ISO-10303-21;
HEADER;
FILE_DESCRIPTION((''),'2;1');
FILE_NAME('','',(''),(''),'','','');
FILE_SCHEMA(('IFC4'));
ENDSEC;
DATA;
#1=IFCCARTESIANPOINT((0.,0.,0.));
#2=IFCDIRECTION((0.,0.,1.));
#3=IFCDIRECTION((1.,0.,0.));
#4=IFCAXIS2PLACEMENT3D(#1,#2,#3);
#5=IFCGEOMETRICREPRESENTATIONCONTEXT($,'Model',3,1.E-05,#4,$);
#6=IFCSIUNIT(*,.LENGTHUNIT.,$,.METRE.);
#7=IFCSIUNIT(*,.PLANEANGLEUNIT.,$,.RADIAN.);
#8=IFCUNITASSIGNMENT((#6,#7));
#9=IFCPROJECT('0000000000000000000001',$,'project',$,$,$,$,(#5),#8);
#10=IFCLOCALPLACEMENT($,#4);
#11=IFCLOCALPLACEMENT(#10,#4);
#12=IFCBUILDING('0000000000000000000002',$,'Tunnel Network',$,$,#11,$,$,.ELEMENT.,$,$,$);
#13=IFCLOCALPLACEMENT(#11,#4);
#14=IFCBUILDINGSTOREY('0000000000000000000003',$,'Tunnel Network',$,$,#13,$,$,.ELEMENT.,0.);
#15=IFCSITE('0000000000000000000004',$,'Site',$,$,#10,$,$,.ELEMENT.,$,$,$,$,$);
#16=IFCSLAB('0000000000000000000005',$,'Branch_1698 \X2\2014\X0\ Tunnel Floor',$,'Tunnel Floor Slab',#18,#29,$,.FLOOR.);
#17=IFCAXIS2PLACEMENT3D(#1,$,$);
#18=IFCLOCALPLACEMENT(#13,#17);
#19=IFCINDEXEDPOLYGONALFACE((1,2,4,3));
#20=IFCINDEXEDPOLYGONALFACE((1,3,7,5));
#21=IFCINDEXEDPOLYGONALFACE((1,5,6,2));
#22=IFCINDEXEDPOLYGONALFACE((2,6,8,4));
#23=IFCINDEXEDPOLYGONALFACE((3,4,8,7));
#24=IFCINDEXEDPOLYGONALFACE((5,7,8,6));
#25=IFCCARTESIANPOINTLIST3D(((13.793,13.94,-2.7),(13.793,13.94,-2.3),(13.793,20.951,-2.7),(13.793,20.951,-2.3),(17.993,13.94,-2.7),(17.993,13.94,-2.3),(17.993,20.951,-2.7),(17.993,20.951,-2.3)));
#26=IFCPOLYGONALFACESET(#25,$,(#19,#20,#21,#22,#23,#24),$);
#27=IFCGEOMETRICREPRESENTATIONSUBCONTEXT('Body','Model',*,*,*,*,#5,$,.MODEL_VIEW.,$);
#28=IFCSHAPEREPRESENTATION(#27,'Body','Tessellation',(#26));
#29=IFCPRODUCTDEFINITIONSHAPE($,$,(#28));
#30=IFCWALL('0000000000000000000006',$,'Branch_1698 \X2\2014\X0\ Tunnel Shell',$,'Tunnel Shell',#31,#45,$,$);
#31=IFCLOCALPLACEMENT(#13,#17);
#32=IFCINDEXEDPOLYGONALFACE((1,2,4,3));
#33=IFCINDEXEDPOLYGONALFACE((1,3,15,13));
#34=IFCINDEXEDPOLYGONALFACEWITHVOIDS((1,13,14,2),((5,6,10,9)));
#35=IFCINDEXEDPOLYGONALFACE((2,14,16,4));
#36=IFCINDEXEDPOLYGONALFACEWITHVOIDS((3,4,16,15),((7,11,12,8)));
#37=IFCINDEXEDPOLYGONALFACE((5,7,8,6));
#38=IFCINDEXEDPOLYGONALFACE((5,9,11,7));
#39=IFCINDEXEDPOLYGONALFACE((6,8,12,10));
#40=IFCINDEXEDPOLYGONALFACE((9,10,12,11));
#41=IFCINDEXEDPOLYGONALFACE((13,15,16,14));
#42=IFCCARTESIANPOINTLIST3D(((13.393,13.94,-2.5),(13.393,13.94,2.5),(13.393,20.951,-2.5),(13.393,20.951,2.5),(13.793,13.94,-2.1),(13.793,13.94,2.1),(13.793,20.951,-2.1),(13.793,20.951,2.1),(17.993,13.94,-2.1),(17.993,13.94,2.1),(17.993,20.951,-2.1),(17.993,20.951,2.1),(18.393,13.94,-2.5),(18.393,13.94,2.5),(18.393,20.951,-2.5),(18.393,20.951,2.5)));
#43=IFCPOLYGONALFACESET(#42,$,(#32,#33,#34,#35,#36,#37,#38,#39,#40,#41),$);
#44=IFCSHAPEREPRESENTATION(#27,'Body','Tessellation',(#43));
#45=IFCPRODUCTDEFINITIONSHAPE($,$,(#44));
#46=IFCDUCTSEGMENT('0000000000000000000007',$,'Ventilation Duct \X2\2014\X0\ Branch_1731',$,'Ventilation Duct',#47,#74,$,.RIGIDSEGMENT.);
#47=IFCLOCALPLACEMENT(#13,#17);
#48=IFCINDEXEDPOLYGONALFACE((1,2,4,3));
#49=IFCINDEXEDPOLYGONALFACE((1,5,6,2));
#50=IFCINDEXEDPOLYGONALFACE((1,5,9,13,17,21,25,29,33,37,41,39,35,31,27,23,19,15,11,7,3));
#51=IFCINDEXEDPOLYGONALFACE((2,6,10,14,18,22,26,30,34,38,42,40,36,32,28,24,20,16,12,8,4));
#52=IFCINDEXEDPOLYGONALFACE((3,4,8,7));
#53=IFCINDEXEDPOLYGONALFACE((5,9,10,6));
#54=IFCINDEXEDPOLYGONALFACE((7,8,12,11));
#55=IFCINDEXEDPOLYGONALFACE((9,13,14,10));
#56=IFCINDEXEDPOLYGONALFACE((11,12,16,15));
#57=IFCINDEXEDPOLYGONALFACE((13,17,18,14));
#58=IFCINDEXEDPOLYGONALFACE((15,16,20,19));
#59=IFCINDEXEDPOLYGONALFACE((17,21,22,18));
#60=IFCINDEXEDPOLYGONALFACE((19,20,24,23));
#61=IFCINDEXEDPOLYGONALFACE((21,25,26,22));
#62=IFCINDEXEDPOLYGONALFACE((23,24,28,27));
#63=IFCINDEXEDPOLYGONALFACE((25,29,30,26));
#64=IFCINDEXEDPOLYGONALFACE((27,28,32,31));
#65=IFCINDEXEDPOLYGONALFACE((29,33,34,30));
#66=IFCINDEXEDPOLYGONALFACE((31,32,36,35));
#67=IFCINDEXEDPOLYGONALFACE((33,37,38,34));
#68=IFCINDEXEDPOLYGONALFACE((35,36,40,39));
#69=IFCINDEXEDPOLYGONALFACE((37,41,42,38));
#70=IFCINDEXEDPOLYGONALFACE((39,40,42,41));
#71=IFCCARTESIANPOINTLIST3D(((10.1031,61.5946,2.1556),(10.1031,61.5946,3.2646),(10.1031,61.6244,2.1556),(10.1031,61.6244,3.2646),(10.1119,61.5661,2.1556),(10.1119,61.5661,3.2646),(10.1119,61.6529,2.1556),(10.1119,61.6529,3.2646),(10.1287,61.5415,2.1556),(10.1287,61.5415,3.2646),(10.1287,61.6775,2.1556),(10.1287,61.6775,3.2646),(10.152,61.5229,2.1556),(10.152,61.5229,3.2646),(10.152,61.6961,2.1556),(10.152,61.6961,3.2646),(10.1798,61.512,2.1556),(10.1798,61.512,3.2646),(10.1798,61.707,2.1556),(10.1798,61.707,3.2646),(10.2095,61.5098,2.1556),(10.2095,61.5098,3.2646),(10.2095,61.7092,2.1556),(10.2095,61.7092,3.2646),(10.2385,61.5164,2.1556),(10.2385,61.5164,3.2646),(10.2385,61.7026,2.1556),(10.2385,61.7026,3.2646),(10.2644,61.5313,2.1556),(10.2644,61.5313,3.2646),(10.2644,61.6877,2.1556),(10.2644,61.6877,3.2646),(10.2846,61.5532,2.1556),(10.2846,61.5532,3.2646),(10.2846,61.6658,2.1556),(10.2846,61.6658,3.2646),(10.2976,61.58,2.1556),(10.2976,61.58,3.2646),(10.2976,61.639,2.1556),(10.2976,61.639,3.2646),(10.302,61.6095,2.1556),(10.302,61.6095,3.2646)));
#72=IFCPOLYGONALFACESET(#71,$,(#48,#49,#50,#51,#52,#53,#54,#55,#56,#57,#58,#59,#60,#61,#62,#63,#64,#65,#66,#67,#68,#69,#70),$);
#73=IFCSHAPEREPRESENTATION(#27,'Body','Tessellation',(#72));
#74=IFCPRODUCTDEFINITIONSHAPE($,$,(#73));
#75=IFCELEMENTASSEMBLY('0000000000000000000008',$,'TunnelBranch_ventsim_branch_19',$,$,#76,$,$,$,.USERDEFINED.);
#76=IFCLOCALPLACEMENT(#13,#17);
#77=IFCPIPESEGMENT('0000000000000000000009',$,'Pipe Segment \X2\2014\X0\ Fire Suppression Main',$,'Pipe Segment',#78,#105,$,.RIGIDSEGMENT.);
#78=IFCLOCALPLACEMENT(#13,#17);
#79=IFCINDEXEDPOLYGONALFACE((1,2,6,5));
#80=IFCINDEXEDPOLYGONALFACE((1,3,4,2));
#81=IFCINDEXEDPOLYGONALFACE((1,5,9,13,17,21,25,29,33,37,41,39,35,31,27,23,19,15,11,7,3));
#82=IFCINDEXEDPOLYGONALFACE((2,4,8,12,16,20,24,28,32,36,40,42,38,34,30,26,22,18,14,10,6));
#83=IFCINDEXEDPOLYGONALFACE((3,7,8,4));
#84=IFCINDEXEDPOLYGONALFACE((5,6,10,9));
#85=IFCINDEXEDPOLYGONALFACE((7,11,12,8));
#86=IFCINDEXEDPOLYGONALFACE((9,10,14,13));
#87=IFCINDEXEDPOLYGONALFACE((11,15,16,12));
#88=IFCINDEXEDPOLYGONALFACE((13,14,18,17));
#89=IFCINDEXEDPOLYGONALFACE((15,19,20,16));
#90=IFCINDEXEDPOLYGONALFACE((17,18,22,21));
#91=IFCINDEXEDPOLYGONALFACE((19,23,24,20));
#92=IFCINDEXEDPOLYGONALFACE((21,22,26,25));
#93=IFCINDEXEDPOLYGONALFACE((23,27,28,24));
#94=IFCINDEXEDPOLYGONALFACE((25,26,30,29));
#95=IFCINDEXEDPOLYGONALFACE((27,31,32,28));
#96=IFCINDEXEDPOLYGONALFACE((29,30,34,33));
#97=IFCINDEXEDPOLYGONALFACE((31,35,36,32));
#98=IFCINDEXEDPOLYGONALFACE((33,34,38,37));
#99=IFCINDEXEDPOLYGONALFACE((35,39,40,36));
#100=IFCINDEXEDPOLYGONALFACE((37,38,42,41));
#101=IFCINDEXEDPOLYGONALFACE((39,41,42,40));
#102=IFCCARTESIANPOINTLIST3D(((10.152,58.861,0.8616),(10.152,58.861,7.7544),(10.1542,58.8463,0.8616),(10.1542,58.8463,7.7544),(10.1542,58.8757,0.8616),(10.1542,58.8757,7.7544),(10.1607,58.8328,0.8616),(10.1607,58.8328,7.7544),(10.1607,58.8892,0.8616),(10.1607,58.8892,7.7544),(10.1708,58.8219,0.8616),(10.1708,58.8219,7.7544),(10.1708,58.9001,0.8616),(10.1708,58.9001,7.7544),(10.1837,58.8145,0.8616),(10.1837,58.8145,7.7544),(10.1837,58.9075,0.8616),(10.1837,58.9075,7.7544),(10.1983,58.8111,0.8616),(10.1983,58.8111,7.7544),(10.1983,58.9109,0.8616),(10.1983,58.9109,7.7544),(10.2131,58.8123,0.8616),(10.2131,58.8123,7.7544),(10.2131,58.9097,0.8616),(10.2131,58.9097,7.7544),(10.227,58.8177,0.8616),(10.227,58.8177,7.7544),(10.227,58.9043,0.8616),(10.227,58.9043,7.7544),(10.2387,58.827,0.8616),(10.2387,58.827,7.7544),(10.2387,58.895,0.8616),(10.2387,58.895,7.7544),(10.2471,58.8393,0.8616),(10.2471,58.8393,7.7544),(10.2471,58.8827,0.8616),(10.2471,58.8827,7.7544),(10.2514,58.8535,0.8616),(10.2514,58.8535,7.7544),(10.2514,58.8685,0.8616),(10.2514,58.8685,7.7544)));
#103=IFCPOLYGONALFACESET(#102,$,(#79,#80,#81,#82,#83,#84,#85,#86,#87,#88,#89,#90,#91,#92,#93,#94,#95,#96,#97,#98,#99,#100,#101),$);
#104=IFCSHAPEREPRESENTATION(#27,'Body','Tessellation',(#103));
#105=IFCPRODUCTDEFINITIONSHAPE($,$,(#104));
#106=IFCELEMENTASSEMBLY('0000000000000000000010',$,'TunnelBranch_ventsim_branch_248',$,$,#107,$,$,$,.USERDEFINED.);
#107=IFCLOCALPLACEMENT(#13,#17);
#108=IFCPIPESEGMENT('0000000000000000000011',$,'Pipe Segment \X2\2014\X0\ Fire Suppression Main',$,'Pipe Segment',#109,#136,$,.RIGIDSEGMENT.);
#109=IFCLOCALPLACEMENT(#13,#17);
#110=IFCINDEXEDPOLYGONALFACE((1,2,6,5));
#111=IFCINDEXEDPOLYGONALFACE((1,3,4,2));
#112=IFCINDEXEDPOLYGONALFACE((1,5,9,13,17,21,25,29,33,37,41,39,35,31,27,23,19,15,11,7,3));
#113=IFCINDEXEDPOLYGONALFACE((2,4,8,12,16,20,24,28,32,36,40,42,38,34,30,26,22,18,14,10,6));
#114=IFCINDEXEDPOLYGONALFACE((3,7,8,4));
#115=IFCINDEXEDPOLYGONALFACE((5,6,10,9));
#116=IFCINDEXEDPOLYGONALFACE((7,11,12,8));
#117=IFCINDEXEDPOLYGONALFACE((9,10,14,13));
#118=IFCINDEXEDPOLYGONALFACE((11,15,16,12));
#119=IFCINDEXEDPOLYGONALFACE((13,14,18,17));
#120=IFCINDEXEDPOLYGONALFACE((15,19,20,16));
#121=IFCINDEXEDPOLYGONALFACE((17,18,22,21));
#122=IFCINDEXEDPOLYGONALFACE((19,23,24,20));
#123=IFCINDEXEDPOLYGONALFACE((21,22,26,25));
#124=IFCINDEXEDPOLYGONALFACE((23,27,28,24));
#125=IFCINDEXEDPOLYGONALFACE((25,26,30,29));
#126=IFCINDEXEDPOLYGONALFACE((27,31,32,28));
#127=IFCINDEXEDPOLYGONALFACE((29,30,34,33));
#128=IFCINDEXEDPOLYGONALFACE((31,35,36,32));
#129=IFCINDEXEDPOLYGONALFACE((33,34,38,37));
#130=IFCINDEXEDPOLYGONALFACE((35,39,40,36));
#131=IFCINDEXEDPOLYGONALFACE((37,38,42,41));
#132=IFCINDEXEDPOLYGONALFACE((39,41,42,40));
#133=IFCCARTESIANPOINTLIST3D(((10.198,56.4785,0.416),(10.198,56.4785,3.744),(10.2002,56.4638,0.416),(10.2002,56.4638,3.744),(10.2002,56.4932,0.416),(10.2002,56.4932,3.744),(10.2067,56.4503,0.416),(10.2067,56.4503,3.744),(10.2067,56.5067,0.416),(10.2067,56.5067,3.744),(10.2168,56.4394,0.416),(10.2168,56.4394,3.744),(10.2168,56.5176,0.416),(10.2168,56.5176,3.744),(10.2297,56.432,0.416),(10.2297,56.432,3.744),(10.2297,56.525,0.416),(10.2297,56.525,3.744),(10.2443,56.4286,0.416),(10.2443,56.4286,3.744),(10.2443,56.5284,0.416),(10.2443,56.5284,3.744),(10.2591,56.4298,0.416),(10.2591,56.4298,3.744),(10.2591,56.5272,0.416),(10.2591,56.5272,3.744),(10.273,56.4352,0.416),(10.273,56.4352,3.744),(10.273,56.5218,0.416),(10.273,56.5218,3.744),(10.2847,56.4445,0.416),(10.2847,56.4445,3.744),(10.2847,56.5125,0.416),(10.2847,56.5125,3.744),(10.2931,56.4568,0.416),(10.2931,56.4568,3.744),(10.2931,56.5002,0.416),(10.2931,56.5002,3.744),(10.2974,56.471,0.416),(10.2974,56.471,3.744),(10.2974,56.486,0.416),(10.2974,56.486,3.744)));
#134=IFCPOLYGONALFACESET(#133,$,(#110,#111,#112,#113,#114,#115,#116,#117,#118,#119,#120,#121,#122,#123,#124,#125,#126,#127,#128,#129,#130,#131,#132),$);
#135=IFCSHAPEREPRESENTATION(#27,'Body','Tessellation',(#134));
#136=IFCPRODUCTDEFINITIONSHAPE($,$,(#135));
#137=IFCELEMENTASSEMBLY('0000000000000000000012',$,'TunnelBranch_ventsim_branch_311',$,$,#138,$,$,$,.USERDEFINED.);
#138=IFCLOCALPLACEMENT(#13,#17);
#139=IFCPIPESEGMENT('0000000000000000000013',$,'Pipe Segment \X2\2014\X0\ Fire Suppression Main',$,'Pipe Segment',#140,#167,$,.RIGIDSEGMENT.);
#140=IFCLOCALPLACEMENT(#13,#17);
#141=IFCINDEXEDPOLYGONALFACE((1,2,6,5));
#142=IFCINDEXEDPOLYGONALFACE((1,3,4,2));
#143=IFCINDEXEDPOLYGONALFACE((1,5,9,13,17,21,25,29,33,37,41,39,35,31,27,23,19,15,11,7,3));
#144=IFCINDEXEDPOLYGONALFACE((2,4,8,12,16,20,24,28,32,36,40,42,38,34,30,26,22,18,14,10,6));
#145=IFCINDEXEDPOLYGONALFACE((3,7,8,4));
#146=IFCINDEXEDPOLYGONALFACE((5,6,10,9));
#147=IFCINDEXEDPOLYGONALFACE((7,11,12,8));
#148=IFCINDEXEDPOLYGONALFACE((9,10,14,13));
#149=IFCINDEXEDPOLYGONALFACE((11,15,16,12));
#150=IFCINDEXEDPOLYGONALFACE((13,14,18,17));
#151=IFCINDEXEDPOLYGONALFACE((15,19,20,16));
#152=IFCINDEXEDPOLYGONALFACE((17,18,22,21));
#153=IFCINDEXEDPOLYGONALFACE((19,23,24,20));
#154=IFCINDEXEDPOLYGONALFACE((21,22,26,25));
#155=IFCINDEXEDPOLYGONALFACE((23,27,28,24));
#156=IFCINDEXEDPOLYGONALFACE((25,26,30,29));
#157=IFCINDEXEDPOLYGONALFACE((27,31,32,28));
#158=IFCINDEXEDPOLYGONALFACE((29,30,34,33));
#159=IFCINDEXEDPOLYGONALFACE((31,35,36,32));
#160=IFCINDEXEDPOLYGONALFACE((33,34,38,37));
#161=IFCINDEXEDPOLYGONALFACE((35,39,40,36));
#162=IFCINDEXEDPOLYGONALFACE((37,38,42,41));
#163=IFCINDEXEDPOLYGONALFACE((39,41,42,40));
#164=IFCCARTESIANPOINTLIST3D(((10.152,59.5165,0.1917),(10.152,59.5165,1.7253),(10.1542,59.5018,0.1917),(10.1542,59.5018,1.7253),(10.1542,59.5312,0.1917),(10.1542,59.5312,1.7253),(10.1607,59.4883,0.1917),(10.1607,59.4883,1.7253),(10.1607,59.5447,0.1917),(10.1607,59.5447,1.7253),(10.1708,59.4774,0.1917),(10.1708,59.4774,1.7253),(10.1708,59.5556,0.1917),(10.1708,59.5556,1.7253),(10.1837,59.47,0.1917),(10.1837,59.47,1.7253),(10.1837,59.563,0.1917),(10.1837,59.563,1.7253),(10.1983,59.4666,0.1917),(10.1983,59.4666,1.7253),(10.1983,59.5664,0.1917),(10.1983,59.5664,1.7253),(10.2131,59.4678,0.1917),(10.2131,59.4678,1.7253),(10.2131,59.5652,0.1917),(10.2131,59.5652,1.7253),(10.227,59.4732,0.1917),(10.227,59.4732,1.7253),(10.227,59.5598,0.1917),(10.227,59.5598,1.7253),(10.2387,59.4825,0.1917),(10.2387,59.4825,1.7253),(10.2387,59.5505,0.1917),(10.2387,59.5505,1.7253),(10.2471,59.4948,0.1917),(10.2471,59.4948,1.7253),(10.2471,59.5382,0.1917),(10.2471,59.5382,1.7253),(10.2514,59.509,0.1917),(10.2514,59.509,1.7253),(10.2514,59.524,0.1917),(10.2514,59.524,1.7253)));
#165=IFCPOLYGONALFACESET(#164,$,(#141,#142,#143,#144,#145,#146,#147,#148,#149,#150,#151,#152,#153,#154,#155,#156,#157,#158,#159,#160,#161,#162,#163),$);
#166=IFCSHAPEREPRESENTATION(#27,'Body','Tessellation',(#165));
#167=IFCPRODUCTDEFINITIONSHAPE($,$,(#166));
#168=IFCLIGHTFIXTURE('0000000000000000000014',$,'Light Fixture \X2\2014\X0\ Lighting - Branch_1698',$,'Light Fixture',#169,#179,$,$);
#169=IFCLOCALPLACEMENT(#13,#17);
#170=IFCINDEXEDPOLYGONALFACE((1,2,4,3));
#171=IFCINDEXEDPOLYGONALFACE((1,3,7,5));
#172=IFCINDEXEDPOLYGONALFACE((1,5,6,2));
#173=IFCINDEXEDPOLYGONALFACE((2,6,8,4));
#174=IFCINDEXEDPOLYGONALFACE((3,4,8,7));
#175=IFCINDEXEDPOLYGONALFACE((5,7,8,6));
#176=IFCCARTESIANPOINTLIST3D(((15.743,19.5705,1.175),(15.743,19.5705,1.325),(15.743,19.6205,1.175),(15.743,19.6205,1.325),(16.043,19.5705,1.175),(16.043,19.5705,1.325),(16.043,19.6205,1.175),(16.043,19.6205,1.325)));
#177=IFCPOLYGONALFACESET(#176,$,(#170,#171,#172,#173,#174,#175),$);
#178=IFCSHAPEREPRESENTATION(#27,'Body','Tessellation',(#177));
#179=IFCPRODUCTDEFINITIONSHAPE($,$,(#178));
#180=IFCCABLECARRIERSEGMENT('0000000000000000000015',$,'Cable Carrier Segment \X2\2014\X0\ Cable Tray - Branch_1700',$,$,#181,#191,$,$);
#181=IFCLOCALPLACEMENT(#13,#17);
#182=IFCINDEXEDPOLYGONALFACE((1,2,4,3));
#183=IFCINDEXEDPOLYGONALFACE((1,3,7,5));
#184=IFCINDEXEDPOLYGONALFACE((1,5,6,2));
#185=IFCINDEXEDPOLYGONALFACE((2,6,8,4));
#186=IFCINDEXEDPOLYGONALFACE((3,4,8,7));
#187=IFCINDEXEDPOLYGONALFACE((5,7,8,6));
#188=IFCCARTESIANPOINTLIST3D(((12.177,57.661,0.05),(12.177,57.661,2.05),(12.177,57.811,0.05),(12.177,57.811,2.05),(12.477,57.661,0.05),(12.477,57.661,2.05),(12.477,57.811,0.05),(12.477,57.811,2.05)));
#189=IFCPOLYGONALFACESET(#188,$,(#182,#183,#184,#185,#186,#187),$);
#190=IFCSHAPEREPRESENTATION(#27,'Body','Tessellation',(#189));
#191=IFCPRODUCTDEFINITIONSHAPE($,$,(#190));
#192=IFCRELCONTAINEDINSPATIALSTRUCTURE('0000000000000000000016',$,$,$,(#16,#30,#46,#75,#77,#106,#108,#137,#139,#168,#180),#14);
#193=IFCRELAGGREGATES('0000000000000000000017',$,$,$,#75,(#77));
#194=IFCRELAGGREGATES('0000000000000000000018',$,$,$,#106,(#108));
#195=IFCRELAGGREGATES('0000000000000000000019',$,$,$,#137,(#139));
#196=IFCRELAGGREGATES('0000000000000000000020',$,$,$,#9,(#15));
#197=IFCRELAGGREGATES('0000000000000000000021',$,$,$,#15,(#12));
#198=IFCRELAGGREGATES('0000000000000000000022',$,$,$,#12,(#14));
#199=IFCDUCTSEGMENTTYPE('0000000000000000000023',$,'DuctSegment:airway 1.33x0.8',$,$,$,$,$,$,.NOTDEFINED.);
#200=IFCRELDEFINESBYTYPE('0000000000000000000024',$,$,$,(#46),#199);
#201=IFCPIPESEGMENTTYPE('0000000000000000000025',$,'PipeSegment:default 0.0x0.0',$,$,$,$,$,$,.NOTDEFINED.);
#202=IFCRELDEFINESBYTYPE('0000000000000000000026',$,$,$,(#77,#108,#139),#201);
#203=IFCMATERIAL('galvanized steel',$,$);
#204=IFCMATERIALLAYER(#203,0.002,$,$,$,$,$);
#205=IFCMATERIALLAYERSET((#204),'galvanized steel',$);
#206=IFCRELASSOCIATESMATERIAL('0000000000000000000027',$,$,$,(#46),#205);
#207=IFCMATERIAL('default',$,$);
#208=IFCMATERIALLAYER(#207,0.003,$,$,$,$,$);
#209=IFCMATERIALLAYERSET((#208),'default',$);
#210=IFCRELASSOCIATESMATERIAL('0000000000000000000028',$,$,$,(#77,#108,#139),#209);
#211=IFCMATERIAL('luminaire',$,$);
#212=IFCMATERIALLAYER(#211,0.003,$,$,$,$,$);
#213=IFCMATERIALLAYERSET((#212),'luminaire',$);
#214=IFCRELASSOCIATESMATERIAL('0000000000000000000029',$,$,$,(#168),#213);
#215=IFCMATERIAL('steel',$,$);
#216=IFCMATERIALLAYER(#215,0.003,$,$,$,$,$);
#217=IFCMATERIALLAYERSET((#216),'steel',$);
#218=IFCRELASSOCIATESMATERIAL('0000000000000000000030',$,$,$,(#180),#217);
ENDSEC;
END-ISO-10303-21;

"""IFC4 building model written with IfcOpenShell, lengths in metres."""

from ifc_helpers import new_model, entity, si_unit, frame, origin_with_axes, origin_2d_with_axis, place, context, subcontext, project, spatial, rectangle, hollow_rectangle, circle, extrude, material, layer, layer_set, layer_usage, type_object, element, aggregate, save


model = new_model("IFC4")

# Units and contexts
model_context = context("Model", 3, precision=1e-05, world=origin_with_axes())
body_context = subcontext(model_context, "Body", "Model", "MODEL_VIEW")
ifc_project = project(units=[si_unit("LENGTHUNIT", "METRE"), si_unit("PLANEANGLEUNIT", "RADIAN")], contexts=[model_context])

# Site, building, storey
site_placement = place(None, origin_with_axes())
site = spatial("IfcSite", under=ifc_project, at=site_placement, Name="Site", CompositionType="ELEMENT")
building_placement = place(site_placement, origin_with_axes())
building = spatial("IfcBuilding", under=site, at=building_placement, Name="Tunnel Network", CompositionType="ELEMENT")
storey_placement = place(building_placement, origin_with_axes())
storey = spatial("IfcBuildingStorey", under=building, at=storey_placement, Name="Tunnel Network", CompositionType="ELEMENT", Elevation=0.0)

# Slab
placement = place(storey_placement, frame((15.893, 13.94, 0.0), z_axis=(0.0, 0.0, 1.0), x_axis=(0.0, 1.0, 0.0)))
element("IfcSlab", 1, at=placement, inside=storey, Name="Branch_1698 — Tunnel Floor", ObjectType="Tunnel Floor Slab", PredefinedType="FLOOR", context=body_context, shape_type="SweptSolid", body=[
    extrude(rectangle(XDim=0.4, YDim=4.2, at=origin_2d_with_axis()), frame((0.0, 0.0, -2.5), z_axis=(1.0, 0.0, 0.0), x_axis=(0.0, 0.0, 1.0)), (0.0, 0.0, 1.0), 7.011),
])

# Wall
element("IfcWall", 2, at=placement, inside=storey, Name="Branch_1698 — Tunnel Shell", ObjectType="Tunnel Shell", context=body_context, shape_type="SweptSolid", body=[
    extrude(hollow_rectangle(XDim=5.0, YDim=5.0, WallThickness=0.4, at=origin_2d_with_axis()), frame((0.0, 0.0, 0.0), z_axis=(1.0, 0.0, 0.0), x_axis=(0.0, 0.0, 1.0)), (0.0, 0.0, 1.0), 7.011),
])

# Duct segment
ifc_material_1 = material(Name="galvanized steel")
ifc_layer_1 = layer(ifc_material_1, 0.002)
ifc_layer_set_1 = layer_set([ifc_layer_1], Name="galvanized steel")
ifc_layer_usage_1 = layer_usage(ifc_layer_set_1, "AXIS2", "POSITIVE", 0.0)
duct_segment_type = type_object("IfcDuctSegmentType", Name="DuctSegment:airway 1.33x0.8")
duct_segment_placement = place(storey_placement, frame((10.202, 61.6095, 2.1556), z_axis=(0.0, 0.0, 1.0), x_axis=(1.0, 0.0, 0.0)))
element("IfcDuctSegment", 3, at=duct_segment_placement, inside=storey, type_object=duct_segment_type, material=ifc_layer_usage_1, Name="Ventilation Duct — Branch_1731", ObjectType="Ventilation Duct", PredefinedType="RIGIDSEGMENT", context=body_context, shape_type="AdvancedSweptSolid", body=[
    entity("IfcSweptDiskSolid", entity("IfcPolyline", [entity("IfcCartesianPoint", [0.0, 0.0, 0.0]), entity("IfcCartesianPoint", [0.0, 0.0, 1.109])]), 0.1),
])

# Element assemblies, pipe segments
assembly_1_placement = place(storey_placement, frame((10.202, 58.861, 1.0), z_axis=(0.0, 1.0, 0.0), x_axis=(-1.0, 0.0, 0.0)))
assembly_1 = element("IfcElementAssembly", 4, at=assembly_1_placement, inside=storey, Name="TunnelBranch_ventsim_branch_19", PredefinedType="USERDEFINED")
ifc_material_2 = material(Name="default")
ifc_layer_2 = layer(ifc_material_2, 0.003)
ifc_layer_set_2 = layer_set([ifc_layer_2], Name="default")
ifc_layer_usage_2 = layer_usage(ifc_layer_set_2, "AXIS2", "POSITIVE", 0.0)
pipe_segment_type = type_object("IfcPipeSegmentType", Name="PipeSegment:default 0.0x0.0")
pipe_segment_1_placement = place(storey_placement, frame((10.202, 58.861, 0.8616), z_axis=(0.0, 0.0, 1.0), x_axis=(-1.0, 0.0, 0.0)))
pipe_segment_1 = element("IfcPipeSegment", 5, at=pipe_segment_1_placement, inside=storey, type_object=pipe_segment_type, material=ifc_layer_usage_2, Name="Pipe Segment — Fire Suppression Main", ObjectType="Pipe Segment", PredefinedType="RIGIDSEGMENT", context=body_context, shape_type="SweptSolid", body=[
    extrude(circle(Radius=0.05, at=origin_2d_with_axis()), origin_with_axes(), (0.0, 0.0, 1.0), 6.8928),
])
assembly_2_placement = place(storey_placement, frame((10.248, 56.4785, 1.25), z_axis=(0.0, 1.0, 0.0), x_axis=(-1.0, 0.0, 0.0)))
assembly_2 = element("IfcElementAssembly", 6, at=assembly_2_placement, inside=storey, Name="TunnelBranch_ventsim_branch_248", PredefinedType="USERDEFINED")
ifc_layer_usage_3 = layer_usage(ifc_layer_set_2, "AXIS2", "POSITIVE", 0.0)
pipe_segment_2_placement = place(storey_placement, frame((10.248, 56.4785, 0.416), z_axis=(0.0, 0.0, 1.0), x_axis=(-1.0, 0.0, 0.0)))
pipe_segment_2 = element("IfcPipeSegment", 7, at=pipe_segment_2_placement, inside=storey, type_object=pipe_segment_type, material=ifc_layer_usage_3, Name="Pipe Segment — Fire Suppression Main", ObjectType="Pipe Segment", PredefinedType="RIGIDSEGMENT", context=body_context, shape_type="SweptSolid", body=[
    extrude(circle(Radius=0.05, at=origin_2d_with_axis()), origin_with_axes(), (0.0, 0.0, 1.0), 3.328),
])
assembly_3_placement = place(storey_placement, frame((10.202, 59.5165, 1.0), z_axis=(0.0, 1.0, 0.0), x_axis=(-1.0, 0.0, 0.0)))
assembly_3 = element("IfcElementAssembly", 8, at=assembly_3_placement, inside=storey, Name="TunnelBranch_ventsim_branch_311", PredefinedType="USERDEFINED")
ifc_layer_usage_4 = layer_usage(ifc_layer_set_2, "AXIS2", "POSITIVE", 0.0)
pipe_segment_3_placement = place(storey_placement, frame((10.202, 59.5165, 0.1917), z_axis=(0.0, 0.0, 1.0), x_axis=(-1.0, 0.0, 0.0)))
pipe_segment_3 = element("IfcPipeSegment", 9, at=pipe_segment_3_placement, inside=storey, type_object=pipe_segment_type, material=ifc_layer_usage_4, Name="Pipe Segment — Fire Suppression Main", ObjectType="Pipe Segment", PredefinedType="RIGIDSEGMENT", context=body_context, shape_type="SweptSolid", body=[
    extrude(circle(Radius=0.05, at=origin_2d_with_axis()), origin_with_axes(), (0.0, 0.0, 1.0), 1.5336),
])

# Light fixture
ifc_material_3 = material(Name="luminaire")
ifc_layer_3 = layer(ifc_material_3, 0.003)
ifc_layer_set_3 = layer_set([ifc_layer_3], Name="luminaire")
ifc_layer_usage_5 = layer_usage(ifc_layer_set_3, "AXIS2", "POSITIVE", 0.0)
light_fixture_1_placement = place(storey_placement, frame((15.893, 19.5705, 1.25), z_axis=(0.0, 1.0, 0.0), x_axis=(-1.0, 0.0, 0.0)))
element("IfcLightFixture", 10, at=light_fixture_1_placement, inside=storey, material=ifc_layer_usage_5, Name="Light Fixture — Lighting - Branch_1698", ObjectType="Light Fixture", context=body_context, shape_type="SweptSolid", body=[
    extrude(rectangle(XDim=0.3, YDim=0.15, at=origin_2d_with_axis()), origin_with_axes(), (0.0, 0.0, 1.0), 0.05),
])

# Cable carrier segment
ifc_material_4 = material(Name="steel")
ifc_layer_4 = layer(ifc_material_4, 0.003)
ifc_layer_set_4 = layer_set([ifc_layer_4], Name="steel")
ifc_layer_usage_6 = layer_usage(ifc_layer_set_4, "AXIS2", "POSITIVE", 0.0)
cable_carrier_segment_1_placement = place(storey_placement, frame((12.327, 57.736, 0.05), z_axis=(0.0, 0.0, 1.0), x_axis=(-1.0, 0.0, 0.0)))
element("IfcCableCarrierSegment", 11, at=cable_carrier_segment_1_placement, inside=storey, material=ifc_layer_usage_6, Name="Cable Carrier Segment — Cable Tray - Branch_1700", context=body_context, shape_type="SweptSolid", body=[
    extrude(rectangle(XDim=0.3, YDim=0.15, at=origin_2d_with_axis()), origin_with_axes(), (0.0, 0.0, 1.0), 2.0),
])

aggregate(assembly_1, [pipe_segment_1])

aggregate(assembly_2, [pipe_segment_2])

aggregate(assembly_3, [pipe_segment_3])

save(model, "model.ifc")
